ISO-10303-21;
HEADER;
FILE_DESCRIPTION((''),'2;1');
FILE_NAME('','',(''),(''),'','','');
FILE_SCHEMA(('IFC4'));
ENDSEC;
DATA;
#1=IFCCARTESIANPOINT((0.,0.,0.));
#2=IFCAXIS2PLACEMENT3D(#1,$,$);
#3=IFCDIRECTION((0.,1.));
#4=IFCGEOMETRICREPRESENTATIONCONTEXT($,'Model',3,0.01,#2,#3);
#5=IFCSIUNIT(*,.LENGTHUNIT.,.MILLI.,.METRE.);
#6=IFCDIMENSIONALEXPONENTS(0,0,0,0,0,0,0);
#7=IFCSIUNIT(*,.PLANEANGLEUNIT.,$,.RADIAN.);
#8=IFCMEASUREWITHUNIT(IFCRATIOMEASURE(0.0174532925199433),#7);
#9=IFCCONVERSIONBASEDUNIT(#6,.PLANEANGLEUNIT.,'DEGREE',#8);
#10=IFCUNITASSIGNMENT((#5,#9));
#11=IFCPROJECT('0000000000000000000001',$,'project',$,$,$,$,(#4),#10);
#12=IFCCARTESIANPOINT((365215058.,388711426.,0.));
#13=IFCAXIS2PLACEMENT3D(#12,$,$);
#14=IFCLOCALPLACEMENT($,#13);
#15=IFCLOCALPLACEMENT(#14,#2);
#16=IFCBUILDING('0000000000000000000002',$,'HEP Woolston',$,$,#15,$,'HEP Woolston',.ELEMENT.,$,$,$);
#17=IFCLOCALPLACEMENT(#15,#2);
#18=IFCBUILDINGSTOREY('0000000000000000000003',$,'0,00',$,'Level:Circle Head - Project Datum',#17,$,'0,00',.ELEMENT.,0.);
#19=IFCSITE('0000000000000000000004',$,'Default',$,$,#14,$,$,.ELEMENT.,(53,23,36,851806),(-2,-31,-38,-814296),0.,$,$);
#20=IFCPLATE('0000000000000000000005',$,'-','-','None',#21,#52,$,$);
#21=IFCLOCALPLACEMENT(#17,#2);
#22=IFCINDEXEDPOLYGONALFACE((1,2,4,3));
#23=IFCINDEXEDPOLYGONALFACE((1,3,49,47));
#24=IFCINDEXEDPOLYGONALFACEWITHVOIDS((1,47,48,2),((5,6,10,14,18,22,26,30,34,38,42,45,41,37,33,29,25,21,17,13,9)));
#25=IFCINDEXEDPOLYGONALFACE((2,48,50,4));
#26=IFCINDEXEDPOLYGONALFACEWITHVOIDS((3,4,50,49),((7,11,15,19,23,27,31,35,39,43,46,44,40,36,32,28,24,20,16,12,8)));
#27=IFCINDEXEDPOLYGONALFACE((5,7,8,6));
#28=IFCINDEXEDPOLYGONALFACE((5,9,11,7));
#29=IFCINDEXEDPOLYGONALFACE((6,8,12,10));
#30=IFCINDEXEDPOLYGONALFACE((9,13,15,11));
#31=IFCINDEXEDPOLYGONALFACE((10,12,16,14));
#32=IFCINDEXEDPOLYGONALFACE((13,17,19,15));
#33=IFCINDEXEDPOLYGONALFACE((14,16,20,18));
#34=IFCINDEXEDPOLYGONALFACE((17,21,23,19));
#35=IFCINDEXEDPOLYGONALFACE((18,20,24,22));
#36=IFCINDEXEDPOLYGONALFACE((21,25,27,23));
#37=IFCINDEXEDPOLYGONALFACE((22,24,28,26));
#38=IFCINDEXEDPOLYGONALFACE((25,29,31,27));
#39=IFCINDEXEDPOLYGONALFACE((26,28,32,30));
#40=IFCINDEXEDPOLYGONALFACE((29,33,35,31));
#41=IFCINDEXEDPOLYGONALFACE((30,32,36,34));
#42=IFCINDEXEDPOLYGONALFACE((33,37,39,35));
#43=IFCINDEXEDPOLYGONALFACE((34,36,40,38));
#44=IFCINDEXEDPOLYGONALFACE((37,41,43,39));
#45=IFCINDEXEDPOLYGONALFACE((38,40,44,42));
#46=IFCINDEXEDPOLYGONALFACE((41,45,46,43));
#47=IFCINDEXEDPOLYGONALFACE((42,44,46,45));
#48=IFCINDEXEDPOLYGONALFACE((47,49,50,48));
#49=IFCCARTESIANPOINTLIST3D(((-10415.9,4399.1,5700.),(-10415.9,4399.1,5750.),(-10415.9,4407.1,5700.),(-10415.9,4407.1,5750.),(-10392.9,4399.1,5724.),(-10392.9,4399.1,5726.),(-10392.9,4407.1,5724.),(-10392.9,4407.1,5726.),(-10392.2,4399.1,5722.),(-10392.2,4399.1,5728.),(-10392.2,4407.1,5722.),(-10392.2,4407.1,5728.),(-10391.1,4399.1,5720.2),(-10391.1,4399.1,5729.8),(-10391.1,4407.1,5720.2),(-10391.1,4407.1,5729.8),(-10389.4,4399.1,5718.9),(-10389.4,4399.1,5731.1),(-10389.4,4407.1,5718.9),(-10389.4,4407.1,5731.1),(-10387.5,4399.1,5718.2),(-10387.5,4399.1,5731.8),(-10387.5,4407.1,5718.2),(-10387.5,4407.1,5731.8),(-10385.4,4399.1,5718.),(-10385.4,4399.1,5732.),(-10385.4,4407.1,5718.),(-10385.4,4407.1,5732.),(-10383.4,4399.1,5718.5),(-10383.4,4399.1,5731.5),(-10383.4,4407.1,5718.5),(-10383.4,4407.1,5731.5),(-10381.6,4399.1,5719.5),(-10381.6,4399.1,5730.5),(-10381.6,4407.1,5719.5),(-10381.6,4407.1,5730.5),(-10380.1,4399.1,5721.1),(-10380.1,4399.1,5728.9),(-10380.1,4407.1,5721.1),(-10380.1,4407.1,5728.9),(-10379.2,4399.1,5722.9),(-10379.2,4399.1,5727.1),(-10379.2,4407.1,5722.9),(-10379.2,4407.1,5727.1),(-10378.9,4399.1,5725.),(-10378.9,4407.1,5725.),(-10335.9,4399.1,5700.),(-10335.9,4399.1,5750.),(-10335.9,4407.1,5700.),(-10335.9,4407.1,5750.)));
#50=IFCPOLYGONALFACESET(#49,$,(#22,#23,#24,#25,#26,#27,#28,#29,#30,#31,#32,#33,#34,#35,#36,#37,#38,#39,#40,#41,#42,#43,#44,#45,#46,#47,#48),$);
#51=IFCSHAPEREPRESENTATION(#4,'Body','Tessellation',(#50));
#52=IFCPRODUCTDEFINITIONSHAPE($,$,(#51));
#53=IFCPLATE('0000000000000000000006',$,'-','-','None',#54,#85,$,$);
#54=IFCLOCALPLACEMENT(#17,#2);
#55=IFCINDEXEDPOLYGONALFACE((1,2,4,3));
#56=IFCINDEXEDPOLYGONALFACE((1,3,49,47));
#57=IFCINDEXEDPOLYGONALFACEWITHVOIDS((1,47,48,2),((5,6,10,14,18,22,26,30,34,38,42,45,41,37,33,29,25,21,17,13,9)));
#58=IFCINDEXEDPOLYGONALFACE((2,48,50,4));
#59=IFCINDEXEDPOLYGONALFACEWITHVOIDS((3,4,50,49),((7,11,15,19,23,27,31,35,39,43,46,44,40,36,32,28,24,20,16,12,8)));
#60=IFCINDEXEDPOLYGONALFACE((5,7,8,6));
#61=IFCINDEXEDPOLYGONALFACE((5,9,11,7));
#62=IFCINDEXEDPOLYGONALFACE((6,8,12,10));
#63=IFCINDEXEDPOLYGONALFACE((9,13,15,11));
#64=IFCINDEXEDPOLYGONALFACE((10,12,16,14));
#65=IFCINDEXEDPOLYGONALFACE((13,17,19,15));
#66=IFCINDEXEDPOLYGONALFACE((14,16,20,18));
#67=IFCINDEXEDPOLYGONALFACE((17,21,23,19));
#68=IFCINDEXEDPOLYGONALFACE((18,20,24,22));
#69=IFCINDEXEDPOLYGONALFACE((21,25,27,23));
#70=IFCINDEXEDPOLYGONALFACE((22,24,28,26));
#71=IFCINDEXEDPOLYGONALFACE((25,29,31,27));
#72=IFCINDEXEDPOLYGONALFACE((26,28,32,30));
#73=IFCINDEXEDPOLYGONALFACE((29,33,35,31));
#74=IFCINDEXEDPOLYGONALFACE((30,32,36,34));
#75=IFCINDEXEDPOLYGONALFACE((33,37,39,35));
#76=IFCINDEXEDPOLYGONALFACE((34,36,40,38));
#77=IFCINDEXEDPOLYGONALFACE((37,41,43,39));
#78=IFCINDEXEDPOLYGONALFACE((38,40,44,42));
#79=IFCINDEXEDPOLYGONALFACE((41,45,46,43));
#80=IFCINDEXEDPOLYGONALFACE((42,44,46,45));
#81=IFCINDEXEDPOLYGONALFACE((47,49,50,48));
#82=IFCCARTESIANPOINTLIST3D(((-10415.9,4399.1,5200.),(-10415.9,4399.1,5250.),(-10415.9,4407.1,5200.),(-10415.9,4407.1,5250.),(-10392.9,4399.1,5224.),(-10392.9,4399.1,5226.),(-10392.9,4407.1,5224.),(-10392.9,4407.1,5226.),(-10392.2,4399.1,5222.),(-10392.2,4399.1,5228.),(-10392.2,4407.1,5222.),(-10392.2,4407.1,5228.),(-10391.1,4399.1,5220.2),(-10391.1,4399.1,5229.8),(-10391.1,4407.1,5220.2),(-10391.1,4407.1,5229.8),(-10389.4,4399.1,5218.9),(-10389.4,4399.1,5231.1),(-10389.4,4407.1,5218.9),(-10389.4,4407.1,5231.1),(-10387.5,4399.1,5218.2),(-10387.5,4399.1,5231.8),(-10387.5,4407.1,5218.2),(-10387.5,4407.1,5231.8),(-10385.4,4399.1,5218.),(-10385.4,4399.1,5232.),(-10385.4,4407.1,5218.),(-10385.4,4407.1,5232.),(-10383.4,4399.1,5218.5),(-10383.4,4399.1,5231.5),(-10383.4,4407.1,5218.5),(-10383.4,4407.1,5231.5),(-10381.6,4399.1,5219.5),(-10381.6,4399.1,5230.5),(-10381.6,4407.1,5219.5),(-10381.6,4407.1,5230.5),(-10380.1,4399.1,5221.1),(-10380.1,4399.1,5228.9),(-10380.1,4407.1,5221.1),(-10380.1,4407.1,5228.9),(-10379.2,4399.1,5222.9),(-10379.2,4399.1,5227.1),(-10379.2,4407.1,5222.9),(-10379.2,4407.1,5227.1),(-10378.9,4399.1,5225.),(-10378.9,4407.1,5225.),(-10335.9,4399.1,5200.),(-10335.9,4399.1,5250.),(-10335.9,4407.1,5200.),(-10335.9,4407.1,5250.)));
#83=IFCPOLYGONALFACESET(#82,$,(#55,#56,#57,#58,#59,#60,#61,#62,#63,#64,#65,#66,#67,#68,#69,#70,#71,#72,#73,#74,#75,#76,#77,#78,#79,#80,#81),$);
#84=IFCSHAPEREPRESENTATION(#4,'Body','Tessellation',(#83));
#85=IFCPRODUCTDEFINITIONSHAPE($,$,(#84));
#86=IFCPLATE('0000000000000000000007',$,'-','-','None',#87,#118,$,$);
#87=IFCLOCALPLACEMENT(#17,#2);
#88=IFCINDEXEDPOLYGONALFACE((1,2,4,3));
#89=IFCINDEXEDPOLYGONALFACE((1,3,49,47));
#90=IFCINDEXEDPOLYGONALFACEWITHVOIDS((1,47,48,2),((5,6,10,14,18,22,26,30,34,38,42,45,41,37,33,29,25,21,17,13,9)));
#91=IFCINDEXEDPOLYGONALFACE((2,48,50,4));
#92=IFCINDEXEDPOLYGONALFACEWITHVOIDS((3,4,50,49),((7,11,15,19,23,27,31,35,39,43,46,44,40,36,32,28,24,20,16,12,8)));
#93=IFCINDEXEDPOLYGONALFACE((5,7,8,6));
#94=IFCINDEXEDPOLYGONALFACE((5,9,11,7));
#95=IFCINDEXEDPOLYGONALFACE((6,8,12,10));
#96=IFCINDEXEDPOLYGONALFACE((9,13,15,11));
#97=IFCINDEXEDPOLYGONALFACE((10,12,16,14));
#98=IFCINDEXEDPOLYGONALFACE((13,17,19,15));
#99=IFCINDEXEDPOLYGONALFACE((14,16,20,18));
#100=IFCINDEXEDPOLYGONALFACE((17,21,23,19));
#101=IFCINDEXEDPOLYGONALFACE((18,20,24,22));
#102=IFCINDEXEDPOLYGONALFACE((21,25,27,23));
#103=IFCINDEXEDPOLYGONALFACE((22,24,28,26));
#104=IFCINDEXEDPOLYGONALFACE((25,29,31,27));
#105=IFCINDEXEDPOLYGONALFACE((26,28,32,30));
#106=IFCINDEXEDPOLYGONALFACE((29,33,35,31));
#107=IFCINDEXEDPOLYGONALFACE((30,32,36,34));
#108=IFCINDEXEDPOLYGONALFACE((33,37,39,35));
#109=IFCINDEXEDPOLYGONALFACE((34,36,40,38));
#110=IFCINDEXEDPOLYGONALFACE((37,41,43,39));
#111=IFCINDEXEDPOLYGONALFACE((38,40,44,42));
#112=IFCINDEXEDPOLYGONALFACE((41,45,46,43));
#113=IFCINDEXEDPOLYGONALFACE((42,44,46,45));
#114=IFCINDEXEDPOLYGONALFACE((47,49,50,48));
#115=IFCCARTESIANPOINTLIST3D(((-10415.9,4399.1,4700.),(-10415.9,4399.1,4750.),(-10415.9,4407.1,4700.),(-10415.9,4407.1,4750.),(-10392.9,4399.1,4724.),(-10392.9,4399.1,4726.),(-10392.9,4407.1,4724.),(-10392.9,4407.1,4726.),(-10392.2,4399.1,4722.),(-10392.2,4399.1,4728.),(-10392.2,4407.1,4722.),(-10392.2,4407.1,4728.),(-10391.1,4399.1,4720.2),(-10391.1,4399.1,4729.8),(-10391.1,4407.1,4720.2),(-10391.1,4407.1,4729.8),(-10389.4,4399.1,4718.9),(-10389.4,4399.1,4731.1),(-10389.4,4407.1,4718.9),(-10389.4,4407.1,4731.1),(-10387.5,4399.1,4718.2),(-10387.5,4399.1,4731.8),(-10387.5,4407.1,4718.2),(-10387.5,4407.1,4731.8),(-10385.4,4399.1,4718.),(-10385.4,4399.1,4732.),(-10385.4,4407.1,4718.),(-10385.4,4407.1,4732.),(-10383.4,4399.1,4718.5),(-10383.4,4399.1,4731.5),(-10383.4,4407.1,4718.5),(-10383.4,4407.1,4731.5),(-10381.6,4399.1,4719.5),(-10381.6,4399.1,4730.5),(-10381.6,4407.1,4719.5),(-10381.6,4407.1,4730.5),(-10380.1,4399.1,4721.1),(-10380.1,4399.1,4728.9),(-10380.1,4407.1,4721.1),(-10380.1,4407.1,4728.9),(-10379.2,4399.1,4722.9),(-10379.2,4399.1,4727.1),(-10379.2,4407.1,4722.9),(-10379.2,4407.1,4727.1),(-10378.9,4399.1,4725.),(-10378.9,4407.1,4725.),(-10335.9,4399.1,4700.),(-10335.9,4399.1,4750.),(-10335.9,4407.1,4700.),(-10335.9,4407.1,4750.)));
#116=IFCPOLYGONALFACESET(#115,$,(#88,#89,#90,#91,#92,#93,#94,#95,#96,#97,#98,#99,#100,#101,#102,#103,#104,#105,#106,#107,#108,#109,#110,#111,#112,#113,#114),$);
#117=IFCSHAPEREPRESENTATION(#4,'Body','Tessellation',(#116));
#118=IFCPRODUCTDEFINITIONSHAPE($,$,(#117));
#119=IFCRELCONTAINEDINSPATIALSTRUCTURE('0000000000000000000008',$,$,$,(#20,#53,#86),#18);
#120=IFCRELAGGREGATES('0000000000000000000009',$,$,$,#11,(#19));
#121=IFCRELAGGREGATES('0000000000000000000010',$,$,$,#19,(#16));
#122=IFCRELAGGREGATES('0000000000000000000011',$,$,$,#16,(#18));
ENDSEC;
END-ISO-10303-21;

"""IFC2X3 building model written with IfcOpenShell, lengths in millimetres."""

from ifc_helpers import new_model, entity, si_unit, converted_unit, direction, frame, frame_2d, origin, origin_with_axes, place, context, project, spatial, polyline, circle, outline, extrude, element, save


model = new_model("IFC2X3")

# Units and contexts
model_context = context("Model", 3, precision=0.01, world=origin(), true_north=direction((0.0, 1.0)))
ifc_project = project(units=[si_unit("LENGTHUNIT", "METRE", prefix="MILLI"), converted_unit("PLANEANGLEUNIT", "DEGREE", entity("IfcRatioMeasure", 0.0174532925199433), si_unit("PLANEANGLEUNIT", "RADIAN"), dimensions=[0, 0, 0, 0, 0, 0, 0])], contexts=[model_context])

# Site, building, storey
site_placement = place(None, frame((365215058.0, 388711426.0, 0.0)))
site = spatial("IfcSite", under=ifc_project, at=site_placement, Name="Default", CompositionType="ELEMENT", RefLatitude=(53, 23, 36, 851806), RefLongitude=(-2, -31, -38, -814296), RefElevation=0.0)
building_placement = place(site_placement, origin())
building = spatial("IfcBuilding", under=site, at=building_placement, Name="HEP Woolston", LongName="HEP Woolston", CompositionType="ELEMENT")
storey_placement = place(building_placement, origin())
storey = spatial("IfcBuildingStorey", under=building, at=storey_placement, Name="0,00", ObjectType="Level:Circle Head - Project Datum", LongName="0,00", CompositionType="ELEMENT", Elevation=0.0)

# Plates, openings
plate_1_placement = place(storey_placement, frame((-10335.9, 4407.1, 5750.0), z_axis=(0.0, 1.0, 0.0), x_axis=(-1.0, 0.0, 0.0)))
plate_1 = element("IfcPlate", 1, at=plate_1_placement, inside=storey, Name="-", Description="-", ObjectType="None", context=model_context, shape_type="SweptSolid", body=[
    extrude(outline(polyline([(0.0, 0.0), (0.0, -50.0), (80.0, -50.0), (80.0, 0.0), (0.0, 0.0)])), origin_with_axes(), (0.0, 0.0, -1.0), 8.0),
])
opening_1_placement = place(plate_1_placement, frame((57.0, -25.0, -8.5), z_axis=(0.0, 0.0, -1.0), x_axis=(-1.0, 0.0, 0.0)))
element("IfcOpeningElement", 2, at=opening_1_placement, cuts=plate_1, ObjectType="Opening", context=model_context, shape_type="SweptSolid", body=[
    extrude(circle(Radius=7.0, at=frame_2d((7.0, 0.0), x_axis=(1.0, 0.0))), origin(), (0.0, 0.0, -1.0), 9.0),
])
plate_2_placement = place(storey_placement, frame((-10335.9, 4407.1, 5250.0), z_axis=(0.0, 1.0, 0.0), x_axis=(-1.0, 0.0, 0.0)))
plate_2 = element("IfcPlate", 3, at=plate_2_placement, inside=storey, Name="-", Description="-", ObjectType="None", context=model_context, shape_type="SweptSolid", body=[
    extrude(outline(polyline([(0.0, 0.0), (0.0, -50.0), (80.0, -50.0), (80.0, 0.0), (0.0, 0.0)])), origin_with_axes(), (0.0, 0.0, -1.0), 8.0),
])
opening_2_placement = place(plate_2_placement, frame((57.0, -25.0, -8.5), z_axis=(0.0, 0.0, -1.0), x_axis=(-1.0, 0.0, 0.0)))
element("IfcOpeningElement", 4, at=opening_2_placement, cuts=plate_2, ObjectType="Opening", context=model_context, shape_type="SweptSolid", body=[
    extrude(circle(Radius=7.0, at=frame_2d((7.0, 0.0), x_axis=(1.0, 0.0))), origin(), (0.0, 0.0, -1.0), 9.0),
])
plate_3_placement = place(storey_placement, frame((-10335.9, 4407.1, 4750.0), z_axis=(0.0, 1.0, 0.0), x_axis=(-1.0, 0.0, 0.0)))
plate_3 = element("IfcPlate", 5, at=plate_3_placement, inside=storey, Name="-", Description="-", ObjectType="None", context=model_context, shape_type="SweptSolid", body=[
    extrude(outline(polyline([(0.0, 0.0), (0.0, -50.0), (80.0, -50.0), (80.0, 0.0), (0.0, 0.0)])), origin_with_axes(), (0.0, 0.0, -1.0), 8.0),
])
opening_3_placement = place(plate_3_placement, frame((57.0, -25.0, -8.5), z_axis=(0.0, 0.0, -1.0), x_axis=(-1.0, 0.0, 0.0)))
element("IfcOpeningElement", 6, at=opening_3_placement, cuts=plate_3, ObjectType="Opening", context=model_context, shape_type="SweptSolid", body=[
    extrude(circle(Radius=7.0, at=frame_2d((7.0, 0.0), x_axis=(1.0, 0.0))), origin(), (0.0, 0.0, -1.0), 9.0),
])

save(model, "model.ifc")
